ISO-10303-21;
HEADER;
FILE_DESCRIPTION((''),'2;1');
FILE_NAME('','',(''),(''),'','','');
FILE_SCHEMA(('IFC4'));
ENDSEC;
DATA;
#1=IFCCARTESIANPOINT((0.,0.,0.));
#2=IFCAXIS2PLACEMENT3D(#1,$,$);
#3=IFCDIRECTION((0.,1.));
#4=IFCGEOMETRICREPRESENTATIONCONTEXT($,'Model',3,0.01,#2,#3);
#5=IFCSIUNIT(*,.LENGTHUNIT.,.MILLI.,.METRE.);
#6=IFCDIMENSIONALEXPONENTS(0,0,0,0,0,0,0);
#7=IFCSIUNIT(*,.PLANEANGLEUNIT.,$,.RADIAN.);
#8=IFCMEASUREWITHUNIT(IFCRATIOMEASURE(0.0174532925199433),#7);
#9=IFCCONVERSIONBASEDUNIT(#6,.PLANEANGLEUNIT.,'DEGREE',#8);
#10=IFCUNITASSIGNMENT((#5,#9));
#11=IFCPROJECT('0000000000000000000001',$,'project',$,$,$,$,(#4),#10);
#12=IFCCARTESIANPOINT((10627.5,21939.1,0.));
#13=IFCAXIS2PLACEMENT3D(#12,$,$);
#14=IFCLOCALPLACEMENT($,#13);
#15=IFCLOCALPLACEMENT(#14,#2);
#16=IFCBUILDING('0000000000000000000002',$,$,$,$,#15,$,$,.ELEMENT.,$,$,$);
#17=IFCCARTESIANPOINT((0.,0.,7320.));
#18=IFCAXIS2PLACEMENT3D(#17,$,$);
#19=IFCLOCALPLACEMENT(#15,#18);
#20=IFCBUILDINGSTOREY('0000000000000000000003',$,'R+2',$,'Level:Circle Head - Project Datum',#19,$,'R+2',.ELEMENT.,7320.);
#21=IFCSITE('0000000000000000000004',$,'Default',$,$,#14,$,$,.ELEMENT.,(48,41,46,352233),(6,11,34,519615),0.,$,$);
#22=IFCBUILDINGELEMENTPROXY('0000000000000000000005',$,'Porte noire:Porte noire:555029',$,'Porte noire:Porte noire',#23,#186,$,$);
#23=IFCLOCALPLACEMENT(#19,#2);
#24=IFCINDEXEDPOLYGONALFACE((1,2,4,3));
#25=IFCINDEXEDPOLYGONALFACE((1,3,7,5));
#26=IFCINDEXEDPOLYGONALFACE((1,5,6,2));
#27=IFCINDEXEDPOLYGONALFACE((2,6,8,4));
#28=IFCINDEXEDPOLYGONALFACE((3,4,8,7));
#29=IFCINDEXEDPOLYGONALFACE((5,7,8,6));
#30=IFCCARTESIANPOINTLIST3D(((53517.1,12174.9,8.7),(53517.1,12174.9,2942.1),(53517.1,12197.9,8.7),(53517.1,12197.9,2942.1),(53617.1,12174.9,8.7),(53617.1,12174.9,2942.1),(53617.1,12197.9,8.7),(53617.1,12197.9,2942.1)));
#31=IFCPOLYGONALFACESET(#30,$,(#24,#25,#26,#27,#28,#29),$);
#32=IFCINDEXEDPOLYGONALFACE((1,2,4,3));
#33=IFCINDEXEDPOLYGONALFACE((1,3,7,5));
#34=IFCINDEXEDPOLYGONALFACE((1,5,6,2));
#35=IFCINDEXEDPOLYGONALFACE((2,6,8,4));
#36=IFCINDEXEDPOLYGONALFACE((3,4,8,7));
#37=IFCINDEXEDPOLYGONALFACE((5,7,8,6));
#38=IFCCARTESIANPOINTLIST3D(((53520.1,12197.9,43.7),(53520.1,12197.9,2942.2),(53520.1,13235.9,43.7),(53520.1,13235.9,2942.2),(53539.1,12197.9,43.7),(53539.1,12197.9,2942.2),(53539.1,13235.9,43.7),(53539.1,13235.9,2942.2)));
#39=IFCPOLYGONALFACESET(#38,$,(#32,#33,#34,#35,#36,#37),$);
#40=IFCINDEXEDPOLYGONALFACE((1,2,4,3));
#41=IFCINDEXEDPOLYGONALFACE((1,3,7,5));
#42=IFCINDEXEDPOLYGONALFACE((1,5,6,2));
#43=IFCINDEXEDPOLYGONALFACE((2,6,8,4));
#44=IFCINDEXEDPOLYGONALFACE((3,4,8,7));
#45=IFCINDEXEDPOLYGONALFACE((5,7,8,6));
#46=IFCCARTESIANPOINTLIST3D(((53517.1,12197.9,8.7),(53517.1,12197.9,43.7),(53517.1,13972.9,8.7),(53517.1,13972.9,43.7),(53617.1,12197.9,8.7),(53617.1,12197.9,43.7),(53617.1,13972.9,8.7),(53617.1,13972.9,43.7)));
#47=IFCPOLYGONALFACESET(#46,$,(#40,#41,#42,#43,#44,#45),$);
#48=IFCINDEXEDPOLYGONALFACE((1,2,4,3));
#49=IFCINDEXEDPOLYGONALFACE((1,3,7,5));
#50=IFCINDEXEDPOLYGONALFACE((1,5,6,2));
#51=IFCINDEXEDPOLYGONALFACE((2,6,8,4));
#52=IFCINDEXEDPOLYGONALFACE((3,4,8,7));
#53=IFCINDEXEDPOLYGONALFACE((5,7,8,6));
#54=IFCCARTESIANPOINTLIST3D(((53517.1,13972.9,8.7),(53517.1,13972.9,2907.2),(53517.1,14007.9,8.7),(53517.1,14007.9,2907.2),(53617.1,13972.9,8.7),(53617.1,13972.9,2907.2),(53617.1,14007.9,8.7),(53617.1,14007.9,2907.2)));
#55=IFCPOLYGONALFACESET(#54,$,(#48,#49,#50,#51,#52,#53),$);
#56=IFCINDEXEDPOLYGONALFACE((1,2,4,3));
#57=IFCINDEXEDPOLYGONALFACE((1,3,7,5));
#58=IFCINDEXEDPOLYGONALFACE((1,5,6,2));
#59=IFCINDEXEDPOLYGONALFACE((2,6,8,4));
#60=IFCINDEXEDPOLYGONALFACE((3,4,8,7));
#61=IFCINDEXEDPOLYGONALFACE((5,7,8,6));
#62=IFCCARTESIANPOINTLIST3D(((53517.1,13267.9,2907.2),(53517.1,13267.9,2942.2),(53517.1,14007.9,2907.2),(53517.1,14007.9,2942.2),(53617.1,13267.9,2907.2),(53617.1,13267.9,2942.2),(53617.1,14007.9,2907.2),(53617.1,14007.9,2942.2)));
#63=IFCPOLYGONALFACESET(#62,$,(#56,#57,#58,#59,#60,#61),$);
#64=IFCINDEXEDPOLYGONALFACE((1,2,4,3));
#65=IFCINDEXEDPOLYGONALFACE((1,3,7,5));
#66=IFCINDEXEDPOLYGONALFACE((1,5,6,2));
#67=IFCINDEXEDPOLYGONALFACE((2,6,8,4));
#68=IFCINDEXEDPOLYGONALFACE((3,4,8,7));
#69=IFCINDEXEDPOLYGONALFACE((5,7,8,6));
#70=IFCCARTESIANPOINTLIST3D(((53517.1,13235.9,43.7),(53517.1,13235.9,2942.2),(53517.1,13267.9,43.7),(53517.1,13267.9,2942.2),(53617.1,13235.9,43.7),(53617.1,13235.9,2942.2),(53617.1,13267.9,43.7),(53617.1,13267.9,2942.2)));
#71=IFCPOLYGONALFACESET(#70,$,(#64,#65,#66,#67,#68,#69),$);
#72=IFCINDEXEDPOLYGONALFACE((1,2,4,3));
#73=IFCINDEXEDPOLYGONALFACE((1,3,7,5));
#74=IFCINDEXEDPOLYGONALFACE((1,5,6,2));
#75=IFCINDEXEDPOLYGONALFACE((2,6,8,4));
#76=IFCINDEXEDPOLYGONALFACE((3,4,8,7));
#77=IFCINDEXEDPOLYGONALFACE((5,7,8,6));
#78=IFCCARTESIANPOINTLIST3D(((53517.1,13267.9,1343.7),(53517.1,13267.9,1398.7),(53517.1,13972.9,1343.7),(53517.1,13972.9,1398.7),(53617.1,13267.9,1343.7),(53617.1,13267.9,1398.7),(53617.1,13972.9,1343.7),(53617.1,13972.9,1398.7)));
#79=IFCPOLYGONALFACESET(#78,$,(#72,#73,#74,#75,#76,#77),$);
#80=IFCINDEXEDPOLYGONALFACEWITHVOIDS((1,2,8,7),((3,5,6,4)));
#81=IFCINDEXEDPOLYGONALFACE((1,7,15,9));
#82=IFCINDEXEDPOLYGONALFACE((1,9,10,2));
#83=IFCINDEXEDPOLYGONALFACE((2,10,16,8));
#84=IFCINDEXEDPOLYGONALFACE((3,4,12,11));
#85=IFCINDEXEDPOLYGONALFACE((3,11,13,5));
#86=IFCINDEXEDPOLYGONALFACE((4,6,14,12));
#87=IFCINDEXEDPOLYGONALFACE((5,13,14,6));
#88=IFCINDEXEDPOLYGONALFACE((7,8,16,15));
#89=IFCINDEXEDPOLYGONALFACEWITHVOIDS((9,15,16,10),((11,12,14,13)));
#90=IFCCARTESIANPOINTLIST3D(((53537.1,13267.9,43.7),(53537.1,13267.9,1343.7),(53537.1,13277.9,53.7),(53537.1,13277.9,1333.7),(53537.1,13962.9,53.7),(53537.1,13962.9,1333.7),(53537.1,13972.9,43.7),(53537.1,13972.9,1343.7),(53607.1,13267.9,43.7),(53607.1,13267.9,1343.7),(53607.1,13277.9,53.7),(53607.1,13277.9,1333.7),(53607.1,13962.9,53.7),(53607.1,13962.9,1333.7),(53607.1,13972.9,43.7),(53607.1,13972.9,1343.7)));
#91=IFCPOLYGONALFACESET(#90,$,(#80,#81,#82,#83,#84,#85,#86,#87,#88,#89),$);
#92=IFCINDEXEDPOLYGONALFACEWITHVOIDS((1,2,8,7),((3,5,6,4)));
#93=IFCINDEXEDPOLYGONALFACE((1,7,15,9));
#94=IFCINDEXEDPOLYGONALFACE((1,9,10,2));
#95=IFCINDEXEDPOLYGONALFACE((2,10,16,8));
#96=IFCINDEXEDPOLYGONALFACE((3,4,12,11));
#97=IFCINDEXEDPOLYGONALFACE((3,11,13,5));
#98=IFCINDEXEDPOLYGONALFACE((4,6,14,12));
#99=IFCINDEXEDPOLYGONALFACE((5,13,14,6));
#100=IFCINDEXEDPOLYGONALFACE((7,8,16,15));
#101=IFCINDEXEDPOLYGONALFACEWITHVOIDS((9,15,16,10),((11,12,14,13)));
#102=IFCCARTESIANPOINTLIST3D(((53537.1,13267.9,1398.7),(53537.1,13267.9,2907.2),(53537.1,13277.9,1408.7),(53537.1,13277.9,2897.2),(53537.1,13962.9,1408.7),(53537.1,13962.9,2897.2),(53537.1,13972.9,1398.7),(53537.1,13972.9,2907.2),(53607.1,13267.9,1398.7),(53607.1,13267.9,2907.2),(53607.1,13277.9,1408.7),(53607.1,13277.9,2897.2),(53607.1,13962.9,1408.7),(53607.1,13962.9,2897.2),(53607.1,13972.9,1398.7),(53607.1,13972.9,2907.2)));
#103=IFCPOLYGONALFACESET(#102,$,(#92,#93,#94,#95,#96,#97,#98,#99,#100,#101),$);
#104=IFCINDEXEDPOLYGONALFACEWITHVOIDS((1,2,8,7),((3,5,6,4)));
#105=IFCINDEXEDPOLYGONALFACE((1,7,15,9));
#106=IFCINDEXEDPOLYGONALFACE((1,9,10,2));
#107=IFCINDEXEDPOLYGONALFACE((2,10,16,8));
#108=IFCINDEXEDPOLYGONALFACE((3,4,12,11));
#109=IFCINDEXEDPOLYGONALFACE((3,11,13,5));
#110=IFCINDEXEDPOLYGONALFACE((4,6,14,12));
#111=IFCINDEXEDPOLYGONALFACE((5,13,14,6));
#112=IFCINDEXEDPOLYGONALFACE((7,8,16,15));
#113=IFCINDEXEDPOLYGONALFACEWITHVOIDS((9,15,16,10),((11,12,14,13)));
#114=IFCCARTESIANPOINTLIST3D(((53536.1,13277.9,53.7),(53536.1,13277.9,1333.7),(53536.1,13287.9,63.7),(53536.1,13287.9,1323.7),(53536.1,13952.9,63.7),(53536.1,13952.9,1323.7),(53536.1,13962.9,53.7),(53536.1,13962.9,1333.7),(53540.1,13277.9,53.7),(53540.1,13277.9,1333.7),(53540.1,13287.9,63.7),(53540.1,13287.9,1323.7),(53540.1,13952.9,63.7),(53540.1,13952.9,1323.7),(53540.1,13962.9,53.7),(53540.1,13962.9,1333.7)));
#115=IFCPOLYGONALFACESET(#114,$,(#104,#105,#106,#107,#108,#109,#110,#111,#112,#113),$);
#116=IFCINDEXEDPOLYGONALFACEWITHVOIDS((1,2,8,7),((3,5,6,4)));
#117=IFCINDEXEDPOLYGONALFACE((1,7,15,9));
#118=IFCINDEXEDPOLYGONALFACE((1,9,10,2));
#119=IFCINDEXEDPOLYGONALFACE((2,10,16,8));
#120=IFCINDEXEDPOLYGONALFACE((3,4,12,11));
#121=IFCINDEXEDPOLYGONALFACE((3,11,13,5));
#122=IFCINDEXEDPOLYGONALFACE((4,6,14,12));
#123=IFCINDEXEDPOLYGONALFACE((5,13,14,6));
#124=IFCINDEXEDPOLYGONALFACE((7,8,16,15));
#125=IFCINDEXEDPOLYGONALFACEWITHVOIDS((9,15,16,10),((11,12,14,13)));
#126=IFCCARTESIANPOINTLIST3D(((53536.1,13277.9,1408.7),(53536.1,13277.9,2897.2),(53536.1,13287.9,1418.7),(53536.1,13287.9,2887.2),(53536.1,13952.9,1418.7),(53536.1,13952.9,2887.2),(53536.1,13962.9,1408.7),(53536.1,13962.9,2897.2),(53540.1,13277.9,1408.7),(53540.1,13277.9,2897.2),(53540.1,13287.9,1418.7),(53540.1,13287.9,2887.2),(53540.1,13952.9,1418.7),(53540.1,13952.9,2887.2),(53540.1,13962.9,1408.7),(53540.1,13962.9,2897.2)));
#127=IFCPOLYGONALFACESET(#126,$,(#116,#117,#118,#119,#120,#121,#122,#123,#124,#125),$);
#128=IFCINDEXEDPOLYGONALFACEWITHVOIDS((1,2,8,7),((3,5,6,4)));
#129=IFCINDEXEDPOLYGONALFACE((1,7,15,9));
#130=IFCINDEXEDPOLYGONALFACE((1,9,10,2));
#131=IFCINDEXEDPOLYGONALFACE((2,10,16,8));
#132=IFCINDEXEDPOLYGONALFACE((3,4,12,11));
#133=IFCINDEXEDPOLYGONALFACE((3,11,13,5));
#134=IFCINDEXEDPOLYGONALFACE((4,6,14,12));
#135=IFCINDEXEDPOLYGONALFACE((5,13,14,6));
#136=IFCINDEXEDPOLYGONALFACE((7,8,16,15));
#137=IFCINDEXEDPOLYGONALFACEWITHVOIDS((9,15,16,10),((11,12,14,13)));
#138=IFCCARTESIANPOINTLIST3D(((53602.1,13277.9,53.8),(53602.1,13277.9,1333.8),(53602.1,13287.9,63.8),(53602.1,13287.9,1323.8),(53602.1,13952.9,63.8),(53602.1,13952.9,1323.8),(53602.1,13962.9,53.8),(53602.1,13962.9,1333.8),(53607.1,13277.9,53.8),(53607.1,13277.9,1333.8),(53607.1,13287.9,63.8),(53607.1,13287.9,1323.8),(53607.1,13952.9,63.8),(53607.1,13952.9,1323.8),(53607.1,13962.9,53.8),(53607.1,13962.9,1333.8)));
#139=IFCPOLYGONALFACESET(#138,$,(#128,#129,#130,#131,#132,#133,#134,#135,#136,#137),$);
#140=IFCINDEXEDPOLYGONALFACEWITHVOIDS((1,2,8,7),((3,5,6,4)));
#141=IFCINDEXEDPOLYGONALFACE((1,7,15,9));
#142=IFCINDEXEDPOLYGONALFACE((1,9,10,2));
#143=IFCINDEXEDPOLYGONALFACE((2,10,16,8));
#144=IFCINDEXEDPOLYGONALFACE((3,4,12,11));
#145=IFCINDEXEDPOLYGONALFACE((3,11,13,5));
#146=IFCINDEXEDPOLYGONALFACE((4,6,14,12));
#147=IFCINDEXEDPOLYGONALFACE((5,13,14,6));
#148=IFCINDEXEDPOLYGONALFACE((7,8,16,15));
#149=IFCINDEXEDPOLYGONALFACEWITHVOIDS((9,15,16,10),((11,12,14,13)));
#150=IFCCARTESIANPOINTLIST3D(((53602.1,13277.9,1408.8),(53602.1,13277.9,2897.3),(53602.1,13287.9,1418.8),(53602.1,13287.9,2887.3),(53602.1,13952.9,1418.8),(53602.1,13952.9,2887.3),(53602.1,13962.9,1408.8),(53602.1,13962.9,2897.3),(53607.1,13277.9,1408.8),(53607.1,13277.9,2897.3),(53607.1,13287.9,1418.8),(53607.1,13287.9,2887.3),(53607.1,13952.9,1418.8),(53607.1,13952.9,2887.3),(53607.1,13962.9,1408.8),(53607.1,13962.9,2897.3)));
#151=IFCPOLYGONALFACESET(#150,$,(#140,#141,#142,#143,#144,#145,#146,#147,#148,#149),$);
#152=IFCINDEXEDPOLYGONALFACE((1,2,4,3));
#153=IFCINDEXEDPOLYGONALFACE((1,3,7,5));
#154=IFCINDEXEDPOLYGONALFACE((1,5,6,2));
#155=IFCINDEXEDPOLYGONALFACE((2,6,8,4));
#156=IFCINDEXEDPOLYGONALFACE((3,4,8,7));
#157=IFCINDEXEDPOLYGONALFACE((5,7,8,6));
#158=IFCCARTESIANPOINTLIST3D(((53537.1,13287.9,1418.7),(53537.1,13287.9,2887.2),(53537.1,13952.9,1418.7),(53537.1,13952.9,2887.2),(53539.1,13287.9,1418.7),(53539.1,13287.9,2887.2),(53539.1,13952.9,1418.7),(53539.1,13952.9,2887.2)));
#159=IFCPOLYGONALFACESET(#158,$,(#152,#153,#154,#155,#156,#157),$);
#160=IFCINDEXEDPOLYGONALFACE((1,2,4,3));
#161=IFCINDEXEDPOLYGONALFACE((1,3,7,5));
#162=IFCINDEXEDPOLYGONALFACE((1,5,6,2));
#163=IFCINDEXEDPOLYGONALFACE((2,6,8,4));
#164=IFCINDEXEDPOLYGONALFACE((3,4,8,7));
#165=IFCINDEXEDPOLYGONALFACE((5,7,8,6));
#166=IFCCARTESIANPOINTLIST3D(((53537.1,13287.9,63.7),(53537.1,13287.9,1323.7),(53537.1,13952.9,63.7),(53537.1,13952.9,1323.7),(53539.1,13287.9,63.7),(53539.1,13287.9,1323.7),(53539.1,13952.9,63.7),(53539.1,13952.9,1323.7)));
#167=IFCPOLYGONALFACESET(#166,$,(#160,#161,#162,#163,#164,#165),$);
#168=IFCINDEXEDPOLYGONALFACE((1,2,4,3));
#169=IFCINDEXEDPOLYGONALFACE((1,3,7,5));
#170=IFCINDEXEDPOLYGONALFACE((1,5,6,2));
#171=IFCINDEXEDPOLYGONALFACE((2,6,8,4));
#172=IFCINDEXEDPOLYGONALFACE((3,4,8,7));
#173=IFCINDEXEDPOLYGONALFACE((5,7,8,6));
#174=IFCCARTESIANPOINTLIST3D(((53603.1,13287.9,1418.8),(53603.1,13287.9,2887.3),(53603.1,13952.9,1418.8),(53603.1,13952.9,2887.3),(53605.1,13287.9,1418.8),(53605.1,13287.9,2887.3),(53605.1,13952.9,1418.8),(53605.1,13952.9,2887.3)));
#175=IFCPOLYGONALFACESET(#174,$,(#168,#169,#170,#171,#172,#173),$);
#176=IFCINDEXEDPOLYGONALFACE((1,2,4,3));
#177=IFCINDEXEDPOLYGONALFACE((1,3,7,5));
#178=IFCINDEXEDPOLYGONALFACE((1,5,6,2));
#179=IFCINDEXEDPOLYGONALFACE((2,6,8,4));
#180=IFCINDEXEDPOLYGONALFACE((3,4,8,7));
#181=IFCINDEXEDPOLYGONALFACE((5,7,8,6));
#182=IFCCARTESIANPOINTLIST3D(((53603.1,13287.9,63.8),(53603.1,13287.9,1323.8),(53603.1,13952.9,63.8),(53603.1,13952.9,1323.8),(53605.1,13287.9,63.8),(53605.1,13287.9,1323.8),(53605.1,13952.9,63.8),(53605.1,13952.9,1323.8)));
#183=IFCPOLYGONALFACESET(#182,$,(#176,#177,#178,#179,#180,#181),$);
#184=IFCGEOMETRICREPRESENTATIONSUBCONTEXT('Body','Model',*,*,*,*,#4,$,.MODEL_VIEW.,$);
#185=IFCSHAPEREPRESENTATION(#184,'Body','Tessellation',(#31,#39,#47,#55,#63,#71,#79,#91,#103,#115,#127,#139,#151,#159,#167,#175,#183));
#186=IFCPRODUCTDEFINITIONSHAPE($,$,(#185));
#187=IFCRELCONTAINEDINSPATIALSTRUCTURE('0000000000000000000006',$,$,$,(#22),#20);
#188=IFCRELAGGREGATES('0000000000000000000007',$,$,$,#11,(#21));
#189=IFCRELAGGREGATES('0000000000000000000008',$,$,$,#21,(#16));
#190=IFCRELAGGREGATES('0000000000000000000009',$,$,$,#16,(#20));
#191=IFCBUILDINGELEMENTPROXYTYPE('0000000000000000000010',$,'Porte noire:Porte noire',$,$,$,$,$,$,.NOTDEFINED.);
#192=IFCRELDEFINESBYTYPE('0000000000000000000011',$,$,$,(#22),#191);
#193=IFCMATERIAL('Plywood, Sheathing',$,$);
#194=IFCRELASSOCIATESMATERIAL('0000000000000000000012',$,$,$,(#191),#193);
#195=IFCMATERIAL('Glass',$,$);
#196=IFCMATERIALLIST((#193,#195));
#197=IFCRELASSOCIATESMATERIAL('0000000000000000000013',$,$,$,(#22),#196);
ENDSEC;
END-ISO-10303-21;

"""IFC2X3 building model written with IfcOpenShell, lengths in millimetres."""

from ifc_helpers import new_model, entity, si_unit, converted_unit, direction, frame, frame_2d, origin, origin_2d_with_axis, place, context, subcontext, project, spatial, polyline, rectangle, outline, extrude, source, transform, mapped, material, material_list, type_object, type_shapes, element, save


model = new_model("IFC2X3")

# Units and contexts
model_context = context("Model", 3, precision=0.01, world=origin(), true_north=direction((0.0, 1.0)))
body_context = subcontext(model_context, "Body", "Model", "MODEL_VIEW")
ifc_project = project(units=[si_unit("LENGTHUNIT", "METRE", prefix="MILLI"), converted_unit("PLANEANGLEUNIT", "DEGREE", entity("IfcRatioMeasure", 0.0174532925199433), si_unit("PLANEANGLEUNIT", "RADIAN"), dimensions=[0, 0, 0, 0, 0, 0, 0])], contexts=[model_context])

# Site, building, storey
site_placement = place(None, frame((10627.5, 21939.1, 0.0)))
site = spatial("IfcSite", under=ifc_project, at=site_placement, Name="Default", CompositionType="ELEMENT", RefLatitude=(48, 41, 46, 352233), RefLongitude=(6, 11, 34, 519615), RefElevation=0.0)
building_placement = place(site_placement, origin())
building = spatial("IfcBuilding", under=site, at=building_placement, CompositionType="ELEMENT")
storey_placement = place(building_placement, frame((0.0, 0.0, 7320.0)))
storey = spatial("IfcBuildingStorey", under=building, at=storey_placement, Name="R+2", ObjectType="Level:Circle Head - Project Datum", LongName="R+2", CompositionType="ELEMENT", Elevation=7320.0)

# Building element proxy
ifc_material_1 = material(Name="Glass")
ifc_material_2 = material(Name="Plywood, Sheathing")
building_element_proxy_type_1 = type_object("IfcBuildingElementProxyType", Name="Porte noire:Porte noire", PredefinedType="NOTDEFINED", material=ifc_material_2)
shared_shape_1 = source(origin(), body_context, "Body", "SweptSolid", [
    extrude(rectangle(XDim=23.0, YDim=100.0, at=frame_2d((0.0, 0.0), x_axis=(1.0, 0.0))), frame((-950.9, 50.0, 8.7), z_axis=(0.0, 0.0, 1.0), x_axis=(-1.0, 0.0, 0.0)), (0.0, 0.0, 1.0), 2933.3),
    extrude(rectangle(XDim=1038.0, YDim=19.0, at=frame_2d((0.0, 0.0), x_axis=(1.0, 0.0))), frame((-420.4, 87.5, 43.7), z_axis=(0.0, 0.0, 1.0), x_axis=(-1.0, 0.0, 0.0)), (0.0, 0.0, 1.0), 2898.5),
    extrude(rectangle(XDim=1775.0, YDim=100.0, at=origin_2d_with_axis()), frame((-51.9, 50.0, 8.7), z_axis=(0.0, 0.0, 1.0), x_axis=(-1.0, 0.0, 0.0)), (0.0, 0.0, 1.0), 35.0),
    extrude(rectangle(XDim=35.0, YDim=100.0, at=origin_2d_with_axis()), frame((853.1, 50.0, 8.7), z_axis=(0.0, 0.0, 1.0), x_axis=(-1.0, 0.0, 0.0)), (0.0, 0.0, 1.0), 2898.5),
    extrude(rectangle(XDim=740.0, YDim=100.0, at=origin_2d_with_axis()), frame((500.6, 50.0, 2907.2), z_axis=(0.0, 0.0, 1.0), x_axis=(-1.0, 0.0, 0.0)), (0.0, 0.0, 1.0), 35.0),
    extrude(rectangle(XDim=32.0, YDim=100.0, at=origin_2d_with_axis()), frame((114.6, 50.0, 43.7), z_axis=(0.0, 0.0, 1.0), x_axis=(-1.0, 0.0, 0.0)), (0.0, 0.0, 1.0), 2898.5),
    extrude(rectangle(XDim=705.0, YDim=100.0, at=origin_2d_with_axis()), frame((483.1, 50.0, 1343.7), z_axis=(0.0, 0.0, 1.0), x_axis=(-1.0, 0.0, 0.0)), (0.0, 0.0, 1.0), 55.0),
    extrude(outline(polyline([(-352.5, -650.0), (352.5, -650.0), (352.5, 650.0), (-352.5, 650.0), (-352.5, -650.0)]), holes=[polyline([(342.5, 640.0), (342.5, -640.0), (-342.5, -640.0), (-342.5, 640.0), (342.5, 640.0)])]), frame((483.1, 10.0, 693.7), z_axis=(0.0, 1.0, 0.0), x_axis=(1.0, 0.0, 0.0)), (0.0, 0.0, 1.0), 70.0),
    extrude(outline(polyline([(-754.2, -352.5), (754.2, -352.5), (754.2, 352.5), (-754.2, 352.5), (-754.2, -352.5)]), holes=[polyline([(744.2, 342.5), (744.2, -342.5), (-744.2, -342.5), (-744.2, 342.5), (744.2, 342.5)])]), frame((483.1, 10.0, 2153.0), z_axis=(0.0, 1.0, 0.0), x_axis=(0.0, 0.0, 1.0)), (0.0, 0.0, 1.0), 70.0),
    extrude(outline(polyline([(-640.0, -342.5), (640.0, -342.5), (640.0, 342.5), (-640.0, 342.5), (-640.0, -342.5)]), holes=[polyline([(630.0, 332.5), (630.0, -332.5), (-630.0, -332.5), (-630.0, 332.5), (630.0, 332.5)])]), frame((483.1, 77.0, 693.7), z_axis=(0.0, 1.0, 0.0), x_axis=(0.0, 0.0, 1.0)), (0.0, 0.0, 1.0), 4.0),
    extrude(outline(polyline([(-744.2, -342.5), (744.2, -342.5), (744.2, 342.5), (-744.2, 342.5), (-744.2, -342.5)]), holes=[polyline([(734.2, 332.5), (734.2, -332.5), (-734.2, -332.5), (-734.2, 332.5), (734.2, 332.5)])]), frame((483.1, 77.0, 2153.0), z_axis=(0.0, 1.0, 0.0), x_axis=(0.0, 0.0, 1.0)), (0.0, 0.0, 1.0), 4.0),
    extrude(outline(polyline([(-640.0, -342.5), (640.0, -342.5), (640.0, 342.5), (-640.0, 342.5), (-640.0, -342.5)]), holes=[polyline([(630.0, 332.5), (630.0, -332.5), (-630.0, -332.5), (-630.0, 332.5), (630.0, 332.5)])]), frame((483.1, 10.0, 693.8), z_axis=(0.0, 1.0, 0.0), x_axis=(0.0, 0.0, 1.0)), (0.0, 0.0, 1.0), 5.0),
    extrude(outline(polyline([(-744.2, -342.5), (744.2, -342.5), (744.2, 342.5), (-744.2, 342.5), (-744.2, -342.5)]), holes=[polyline([(734.2, 332.5), (734.2, -332.5), (-734.2, -332.5), (-734.2, 332.5), (734.2, 332.5)])]), frame((483.1, 10.0, 2153.0), z_axis=(0.0, 1.0, 0.0), x_axis=(0.0, 0.0, 1.0)), (0.0, 0.0, 1.0), 5.0),
    extrude(rectangle(XDim=665.0, YDim=2.0, at=frame_2d((0.0, 0.0), x_axis=(1.0, 0.0))), frame((483.1, 79.0, 1418.7), z_axis=(0.0, 0.0, 1.0), x_axis=(-1.0, 0.0, 0.0)), (0.0, 0.0, 1.0), 1468.5),
    extrude(rectangle(XDim=665.0, YDim=2.0, at=frame_2d((0.0, 0.0), x_axis=(1.0, 0.0))), frame((483.1, 79.0, 63.7), z_axis=(0.0, 0.0, 1.0), x_axis=(-1.0, 0.0, 0.0)), (0.0, 0.0, 1.0), 1260.0),
    extrude(rectangle(XDim=665.0, YDim=2.0, at=frame_2d((0.0, 0.0), x_axis=(1.0, 0.0))), frame((483.1, 13.0, 1418.8), z_axis=(0.0, 0.0, 1.0), x_axis=(-1.0, 0.0, 0.0)), (0.0, 0.0, 1.0), 1468.5),
    extrude(rectangle(XDim=665.0, YDim=2.0, at=frame_2d((0.0, 0.0), x_axis=(1.0, 0.0))), frame((483.1, 13.0, 63.8), z_axis=(0.0, 0.0, 1.0), x_axis=(-1.0, 0.0, 0.0)), (0.0, 0.0, 1.0), 1260.0),
])
type_shapes(building_element_proxy_type_1, [shared_shape_1])
ifc_material_list_1 = material_list([ifc_material_2, ifc_material_1])
proxy_1_placement = place(storey_placement, frame((53617.1, 13137.3, 0.0), z_axis=(0.0, 0.0, 1.0), x_axis=(0.0, 1.0, 0.0)))
element("IfcBuildingElementProxy", 1, at=proxy_1_placement, inside=storey, type_object=building_element_proxy_type_1, material=ifc_material_list_1, Name="Porte noire:Porte noire:555029", ObjectType="Porte noire:Porte noire", context=body_context, shape_type="MappedRepresentation", body=[
    mapped(shared_shape_1, transform((0.0, 0.0, 0.0), scale=1.0)),
])

save(model, "model.ifc")
